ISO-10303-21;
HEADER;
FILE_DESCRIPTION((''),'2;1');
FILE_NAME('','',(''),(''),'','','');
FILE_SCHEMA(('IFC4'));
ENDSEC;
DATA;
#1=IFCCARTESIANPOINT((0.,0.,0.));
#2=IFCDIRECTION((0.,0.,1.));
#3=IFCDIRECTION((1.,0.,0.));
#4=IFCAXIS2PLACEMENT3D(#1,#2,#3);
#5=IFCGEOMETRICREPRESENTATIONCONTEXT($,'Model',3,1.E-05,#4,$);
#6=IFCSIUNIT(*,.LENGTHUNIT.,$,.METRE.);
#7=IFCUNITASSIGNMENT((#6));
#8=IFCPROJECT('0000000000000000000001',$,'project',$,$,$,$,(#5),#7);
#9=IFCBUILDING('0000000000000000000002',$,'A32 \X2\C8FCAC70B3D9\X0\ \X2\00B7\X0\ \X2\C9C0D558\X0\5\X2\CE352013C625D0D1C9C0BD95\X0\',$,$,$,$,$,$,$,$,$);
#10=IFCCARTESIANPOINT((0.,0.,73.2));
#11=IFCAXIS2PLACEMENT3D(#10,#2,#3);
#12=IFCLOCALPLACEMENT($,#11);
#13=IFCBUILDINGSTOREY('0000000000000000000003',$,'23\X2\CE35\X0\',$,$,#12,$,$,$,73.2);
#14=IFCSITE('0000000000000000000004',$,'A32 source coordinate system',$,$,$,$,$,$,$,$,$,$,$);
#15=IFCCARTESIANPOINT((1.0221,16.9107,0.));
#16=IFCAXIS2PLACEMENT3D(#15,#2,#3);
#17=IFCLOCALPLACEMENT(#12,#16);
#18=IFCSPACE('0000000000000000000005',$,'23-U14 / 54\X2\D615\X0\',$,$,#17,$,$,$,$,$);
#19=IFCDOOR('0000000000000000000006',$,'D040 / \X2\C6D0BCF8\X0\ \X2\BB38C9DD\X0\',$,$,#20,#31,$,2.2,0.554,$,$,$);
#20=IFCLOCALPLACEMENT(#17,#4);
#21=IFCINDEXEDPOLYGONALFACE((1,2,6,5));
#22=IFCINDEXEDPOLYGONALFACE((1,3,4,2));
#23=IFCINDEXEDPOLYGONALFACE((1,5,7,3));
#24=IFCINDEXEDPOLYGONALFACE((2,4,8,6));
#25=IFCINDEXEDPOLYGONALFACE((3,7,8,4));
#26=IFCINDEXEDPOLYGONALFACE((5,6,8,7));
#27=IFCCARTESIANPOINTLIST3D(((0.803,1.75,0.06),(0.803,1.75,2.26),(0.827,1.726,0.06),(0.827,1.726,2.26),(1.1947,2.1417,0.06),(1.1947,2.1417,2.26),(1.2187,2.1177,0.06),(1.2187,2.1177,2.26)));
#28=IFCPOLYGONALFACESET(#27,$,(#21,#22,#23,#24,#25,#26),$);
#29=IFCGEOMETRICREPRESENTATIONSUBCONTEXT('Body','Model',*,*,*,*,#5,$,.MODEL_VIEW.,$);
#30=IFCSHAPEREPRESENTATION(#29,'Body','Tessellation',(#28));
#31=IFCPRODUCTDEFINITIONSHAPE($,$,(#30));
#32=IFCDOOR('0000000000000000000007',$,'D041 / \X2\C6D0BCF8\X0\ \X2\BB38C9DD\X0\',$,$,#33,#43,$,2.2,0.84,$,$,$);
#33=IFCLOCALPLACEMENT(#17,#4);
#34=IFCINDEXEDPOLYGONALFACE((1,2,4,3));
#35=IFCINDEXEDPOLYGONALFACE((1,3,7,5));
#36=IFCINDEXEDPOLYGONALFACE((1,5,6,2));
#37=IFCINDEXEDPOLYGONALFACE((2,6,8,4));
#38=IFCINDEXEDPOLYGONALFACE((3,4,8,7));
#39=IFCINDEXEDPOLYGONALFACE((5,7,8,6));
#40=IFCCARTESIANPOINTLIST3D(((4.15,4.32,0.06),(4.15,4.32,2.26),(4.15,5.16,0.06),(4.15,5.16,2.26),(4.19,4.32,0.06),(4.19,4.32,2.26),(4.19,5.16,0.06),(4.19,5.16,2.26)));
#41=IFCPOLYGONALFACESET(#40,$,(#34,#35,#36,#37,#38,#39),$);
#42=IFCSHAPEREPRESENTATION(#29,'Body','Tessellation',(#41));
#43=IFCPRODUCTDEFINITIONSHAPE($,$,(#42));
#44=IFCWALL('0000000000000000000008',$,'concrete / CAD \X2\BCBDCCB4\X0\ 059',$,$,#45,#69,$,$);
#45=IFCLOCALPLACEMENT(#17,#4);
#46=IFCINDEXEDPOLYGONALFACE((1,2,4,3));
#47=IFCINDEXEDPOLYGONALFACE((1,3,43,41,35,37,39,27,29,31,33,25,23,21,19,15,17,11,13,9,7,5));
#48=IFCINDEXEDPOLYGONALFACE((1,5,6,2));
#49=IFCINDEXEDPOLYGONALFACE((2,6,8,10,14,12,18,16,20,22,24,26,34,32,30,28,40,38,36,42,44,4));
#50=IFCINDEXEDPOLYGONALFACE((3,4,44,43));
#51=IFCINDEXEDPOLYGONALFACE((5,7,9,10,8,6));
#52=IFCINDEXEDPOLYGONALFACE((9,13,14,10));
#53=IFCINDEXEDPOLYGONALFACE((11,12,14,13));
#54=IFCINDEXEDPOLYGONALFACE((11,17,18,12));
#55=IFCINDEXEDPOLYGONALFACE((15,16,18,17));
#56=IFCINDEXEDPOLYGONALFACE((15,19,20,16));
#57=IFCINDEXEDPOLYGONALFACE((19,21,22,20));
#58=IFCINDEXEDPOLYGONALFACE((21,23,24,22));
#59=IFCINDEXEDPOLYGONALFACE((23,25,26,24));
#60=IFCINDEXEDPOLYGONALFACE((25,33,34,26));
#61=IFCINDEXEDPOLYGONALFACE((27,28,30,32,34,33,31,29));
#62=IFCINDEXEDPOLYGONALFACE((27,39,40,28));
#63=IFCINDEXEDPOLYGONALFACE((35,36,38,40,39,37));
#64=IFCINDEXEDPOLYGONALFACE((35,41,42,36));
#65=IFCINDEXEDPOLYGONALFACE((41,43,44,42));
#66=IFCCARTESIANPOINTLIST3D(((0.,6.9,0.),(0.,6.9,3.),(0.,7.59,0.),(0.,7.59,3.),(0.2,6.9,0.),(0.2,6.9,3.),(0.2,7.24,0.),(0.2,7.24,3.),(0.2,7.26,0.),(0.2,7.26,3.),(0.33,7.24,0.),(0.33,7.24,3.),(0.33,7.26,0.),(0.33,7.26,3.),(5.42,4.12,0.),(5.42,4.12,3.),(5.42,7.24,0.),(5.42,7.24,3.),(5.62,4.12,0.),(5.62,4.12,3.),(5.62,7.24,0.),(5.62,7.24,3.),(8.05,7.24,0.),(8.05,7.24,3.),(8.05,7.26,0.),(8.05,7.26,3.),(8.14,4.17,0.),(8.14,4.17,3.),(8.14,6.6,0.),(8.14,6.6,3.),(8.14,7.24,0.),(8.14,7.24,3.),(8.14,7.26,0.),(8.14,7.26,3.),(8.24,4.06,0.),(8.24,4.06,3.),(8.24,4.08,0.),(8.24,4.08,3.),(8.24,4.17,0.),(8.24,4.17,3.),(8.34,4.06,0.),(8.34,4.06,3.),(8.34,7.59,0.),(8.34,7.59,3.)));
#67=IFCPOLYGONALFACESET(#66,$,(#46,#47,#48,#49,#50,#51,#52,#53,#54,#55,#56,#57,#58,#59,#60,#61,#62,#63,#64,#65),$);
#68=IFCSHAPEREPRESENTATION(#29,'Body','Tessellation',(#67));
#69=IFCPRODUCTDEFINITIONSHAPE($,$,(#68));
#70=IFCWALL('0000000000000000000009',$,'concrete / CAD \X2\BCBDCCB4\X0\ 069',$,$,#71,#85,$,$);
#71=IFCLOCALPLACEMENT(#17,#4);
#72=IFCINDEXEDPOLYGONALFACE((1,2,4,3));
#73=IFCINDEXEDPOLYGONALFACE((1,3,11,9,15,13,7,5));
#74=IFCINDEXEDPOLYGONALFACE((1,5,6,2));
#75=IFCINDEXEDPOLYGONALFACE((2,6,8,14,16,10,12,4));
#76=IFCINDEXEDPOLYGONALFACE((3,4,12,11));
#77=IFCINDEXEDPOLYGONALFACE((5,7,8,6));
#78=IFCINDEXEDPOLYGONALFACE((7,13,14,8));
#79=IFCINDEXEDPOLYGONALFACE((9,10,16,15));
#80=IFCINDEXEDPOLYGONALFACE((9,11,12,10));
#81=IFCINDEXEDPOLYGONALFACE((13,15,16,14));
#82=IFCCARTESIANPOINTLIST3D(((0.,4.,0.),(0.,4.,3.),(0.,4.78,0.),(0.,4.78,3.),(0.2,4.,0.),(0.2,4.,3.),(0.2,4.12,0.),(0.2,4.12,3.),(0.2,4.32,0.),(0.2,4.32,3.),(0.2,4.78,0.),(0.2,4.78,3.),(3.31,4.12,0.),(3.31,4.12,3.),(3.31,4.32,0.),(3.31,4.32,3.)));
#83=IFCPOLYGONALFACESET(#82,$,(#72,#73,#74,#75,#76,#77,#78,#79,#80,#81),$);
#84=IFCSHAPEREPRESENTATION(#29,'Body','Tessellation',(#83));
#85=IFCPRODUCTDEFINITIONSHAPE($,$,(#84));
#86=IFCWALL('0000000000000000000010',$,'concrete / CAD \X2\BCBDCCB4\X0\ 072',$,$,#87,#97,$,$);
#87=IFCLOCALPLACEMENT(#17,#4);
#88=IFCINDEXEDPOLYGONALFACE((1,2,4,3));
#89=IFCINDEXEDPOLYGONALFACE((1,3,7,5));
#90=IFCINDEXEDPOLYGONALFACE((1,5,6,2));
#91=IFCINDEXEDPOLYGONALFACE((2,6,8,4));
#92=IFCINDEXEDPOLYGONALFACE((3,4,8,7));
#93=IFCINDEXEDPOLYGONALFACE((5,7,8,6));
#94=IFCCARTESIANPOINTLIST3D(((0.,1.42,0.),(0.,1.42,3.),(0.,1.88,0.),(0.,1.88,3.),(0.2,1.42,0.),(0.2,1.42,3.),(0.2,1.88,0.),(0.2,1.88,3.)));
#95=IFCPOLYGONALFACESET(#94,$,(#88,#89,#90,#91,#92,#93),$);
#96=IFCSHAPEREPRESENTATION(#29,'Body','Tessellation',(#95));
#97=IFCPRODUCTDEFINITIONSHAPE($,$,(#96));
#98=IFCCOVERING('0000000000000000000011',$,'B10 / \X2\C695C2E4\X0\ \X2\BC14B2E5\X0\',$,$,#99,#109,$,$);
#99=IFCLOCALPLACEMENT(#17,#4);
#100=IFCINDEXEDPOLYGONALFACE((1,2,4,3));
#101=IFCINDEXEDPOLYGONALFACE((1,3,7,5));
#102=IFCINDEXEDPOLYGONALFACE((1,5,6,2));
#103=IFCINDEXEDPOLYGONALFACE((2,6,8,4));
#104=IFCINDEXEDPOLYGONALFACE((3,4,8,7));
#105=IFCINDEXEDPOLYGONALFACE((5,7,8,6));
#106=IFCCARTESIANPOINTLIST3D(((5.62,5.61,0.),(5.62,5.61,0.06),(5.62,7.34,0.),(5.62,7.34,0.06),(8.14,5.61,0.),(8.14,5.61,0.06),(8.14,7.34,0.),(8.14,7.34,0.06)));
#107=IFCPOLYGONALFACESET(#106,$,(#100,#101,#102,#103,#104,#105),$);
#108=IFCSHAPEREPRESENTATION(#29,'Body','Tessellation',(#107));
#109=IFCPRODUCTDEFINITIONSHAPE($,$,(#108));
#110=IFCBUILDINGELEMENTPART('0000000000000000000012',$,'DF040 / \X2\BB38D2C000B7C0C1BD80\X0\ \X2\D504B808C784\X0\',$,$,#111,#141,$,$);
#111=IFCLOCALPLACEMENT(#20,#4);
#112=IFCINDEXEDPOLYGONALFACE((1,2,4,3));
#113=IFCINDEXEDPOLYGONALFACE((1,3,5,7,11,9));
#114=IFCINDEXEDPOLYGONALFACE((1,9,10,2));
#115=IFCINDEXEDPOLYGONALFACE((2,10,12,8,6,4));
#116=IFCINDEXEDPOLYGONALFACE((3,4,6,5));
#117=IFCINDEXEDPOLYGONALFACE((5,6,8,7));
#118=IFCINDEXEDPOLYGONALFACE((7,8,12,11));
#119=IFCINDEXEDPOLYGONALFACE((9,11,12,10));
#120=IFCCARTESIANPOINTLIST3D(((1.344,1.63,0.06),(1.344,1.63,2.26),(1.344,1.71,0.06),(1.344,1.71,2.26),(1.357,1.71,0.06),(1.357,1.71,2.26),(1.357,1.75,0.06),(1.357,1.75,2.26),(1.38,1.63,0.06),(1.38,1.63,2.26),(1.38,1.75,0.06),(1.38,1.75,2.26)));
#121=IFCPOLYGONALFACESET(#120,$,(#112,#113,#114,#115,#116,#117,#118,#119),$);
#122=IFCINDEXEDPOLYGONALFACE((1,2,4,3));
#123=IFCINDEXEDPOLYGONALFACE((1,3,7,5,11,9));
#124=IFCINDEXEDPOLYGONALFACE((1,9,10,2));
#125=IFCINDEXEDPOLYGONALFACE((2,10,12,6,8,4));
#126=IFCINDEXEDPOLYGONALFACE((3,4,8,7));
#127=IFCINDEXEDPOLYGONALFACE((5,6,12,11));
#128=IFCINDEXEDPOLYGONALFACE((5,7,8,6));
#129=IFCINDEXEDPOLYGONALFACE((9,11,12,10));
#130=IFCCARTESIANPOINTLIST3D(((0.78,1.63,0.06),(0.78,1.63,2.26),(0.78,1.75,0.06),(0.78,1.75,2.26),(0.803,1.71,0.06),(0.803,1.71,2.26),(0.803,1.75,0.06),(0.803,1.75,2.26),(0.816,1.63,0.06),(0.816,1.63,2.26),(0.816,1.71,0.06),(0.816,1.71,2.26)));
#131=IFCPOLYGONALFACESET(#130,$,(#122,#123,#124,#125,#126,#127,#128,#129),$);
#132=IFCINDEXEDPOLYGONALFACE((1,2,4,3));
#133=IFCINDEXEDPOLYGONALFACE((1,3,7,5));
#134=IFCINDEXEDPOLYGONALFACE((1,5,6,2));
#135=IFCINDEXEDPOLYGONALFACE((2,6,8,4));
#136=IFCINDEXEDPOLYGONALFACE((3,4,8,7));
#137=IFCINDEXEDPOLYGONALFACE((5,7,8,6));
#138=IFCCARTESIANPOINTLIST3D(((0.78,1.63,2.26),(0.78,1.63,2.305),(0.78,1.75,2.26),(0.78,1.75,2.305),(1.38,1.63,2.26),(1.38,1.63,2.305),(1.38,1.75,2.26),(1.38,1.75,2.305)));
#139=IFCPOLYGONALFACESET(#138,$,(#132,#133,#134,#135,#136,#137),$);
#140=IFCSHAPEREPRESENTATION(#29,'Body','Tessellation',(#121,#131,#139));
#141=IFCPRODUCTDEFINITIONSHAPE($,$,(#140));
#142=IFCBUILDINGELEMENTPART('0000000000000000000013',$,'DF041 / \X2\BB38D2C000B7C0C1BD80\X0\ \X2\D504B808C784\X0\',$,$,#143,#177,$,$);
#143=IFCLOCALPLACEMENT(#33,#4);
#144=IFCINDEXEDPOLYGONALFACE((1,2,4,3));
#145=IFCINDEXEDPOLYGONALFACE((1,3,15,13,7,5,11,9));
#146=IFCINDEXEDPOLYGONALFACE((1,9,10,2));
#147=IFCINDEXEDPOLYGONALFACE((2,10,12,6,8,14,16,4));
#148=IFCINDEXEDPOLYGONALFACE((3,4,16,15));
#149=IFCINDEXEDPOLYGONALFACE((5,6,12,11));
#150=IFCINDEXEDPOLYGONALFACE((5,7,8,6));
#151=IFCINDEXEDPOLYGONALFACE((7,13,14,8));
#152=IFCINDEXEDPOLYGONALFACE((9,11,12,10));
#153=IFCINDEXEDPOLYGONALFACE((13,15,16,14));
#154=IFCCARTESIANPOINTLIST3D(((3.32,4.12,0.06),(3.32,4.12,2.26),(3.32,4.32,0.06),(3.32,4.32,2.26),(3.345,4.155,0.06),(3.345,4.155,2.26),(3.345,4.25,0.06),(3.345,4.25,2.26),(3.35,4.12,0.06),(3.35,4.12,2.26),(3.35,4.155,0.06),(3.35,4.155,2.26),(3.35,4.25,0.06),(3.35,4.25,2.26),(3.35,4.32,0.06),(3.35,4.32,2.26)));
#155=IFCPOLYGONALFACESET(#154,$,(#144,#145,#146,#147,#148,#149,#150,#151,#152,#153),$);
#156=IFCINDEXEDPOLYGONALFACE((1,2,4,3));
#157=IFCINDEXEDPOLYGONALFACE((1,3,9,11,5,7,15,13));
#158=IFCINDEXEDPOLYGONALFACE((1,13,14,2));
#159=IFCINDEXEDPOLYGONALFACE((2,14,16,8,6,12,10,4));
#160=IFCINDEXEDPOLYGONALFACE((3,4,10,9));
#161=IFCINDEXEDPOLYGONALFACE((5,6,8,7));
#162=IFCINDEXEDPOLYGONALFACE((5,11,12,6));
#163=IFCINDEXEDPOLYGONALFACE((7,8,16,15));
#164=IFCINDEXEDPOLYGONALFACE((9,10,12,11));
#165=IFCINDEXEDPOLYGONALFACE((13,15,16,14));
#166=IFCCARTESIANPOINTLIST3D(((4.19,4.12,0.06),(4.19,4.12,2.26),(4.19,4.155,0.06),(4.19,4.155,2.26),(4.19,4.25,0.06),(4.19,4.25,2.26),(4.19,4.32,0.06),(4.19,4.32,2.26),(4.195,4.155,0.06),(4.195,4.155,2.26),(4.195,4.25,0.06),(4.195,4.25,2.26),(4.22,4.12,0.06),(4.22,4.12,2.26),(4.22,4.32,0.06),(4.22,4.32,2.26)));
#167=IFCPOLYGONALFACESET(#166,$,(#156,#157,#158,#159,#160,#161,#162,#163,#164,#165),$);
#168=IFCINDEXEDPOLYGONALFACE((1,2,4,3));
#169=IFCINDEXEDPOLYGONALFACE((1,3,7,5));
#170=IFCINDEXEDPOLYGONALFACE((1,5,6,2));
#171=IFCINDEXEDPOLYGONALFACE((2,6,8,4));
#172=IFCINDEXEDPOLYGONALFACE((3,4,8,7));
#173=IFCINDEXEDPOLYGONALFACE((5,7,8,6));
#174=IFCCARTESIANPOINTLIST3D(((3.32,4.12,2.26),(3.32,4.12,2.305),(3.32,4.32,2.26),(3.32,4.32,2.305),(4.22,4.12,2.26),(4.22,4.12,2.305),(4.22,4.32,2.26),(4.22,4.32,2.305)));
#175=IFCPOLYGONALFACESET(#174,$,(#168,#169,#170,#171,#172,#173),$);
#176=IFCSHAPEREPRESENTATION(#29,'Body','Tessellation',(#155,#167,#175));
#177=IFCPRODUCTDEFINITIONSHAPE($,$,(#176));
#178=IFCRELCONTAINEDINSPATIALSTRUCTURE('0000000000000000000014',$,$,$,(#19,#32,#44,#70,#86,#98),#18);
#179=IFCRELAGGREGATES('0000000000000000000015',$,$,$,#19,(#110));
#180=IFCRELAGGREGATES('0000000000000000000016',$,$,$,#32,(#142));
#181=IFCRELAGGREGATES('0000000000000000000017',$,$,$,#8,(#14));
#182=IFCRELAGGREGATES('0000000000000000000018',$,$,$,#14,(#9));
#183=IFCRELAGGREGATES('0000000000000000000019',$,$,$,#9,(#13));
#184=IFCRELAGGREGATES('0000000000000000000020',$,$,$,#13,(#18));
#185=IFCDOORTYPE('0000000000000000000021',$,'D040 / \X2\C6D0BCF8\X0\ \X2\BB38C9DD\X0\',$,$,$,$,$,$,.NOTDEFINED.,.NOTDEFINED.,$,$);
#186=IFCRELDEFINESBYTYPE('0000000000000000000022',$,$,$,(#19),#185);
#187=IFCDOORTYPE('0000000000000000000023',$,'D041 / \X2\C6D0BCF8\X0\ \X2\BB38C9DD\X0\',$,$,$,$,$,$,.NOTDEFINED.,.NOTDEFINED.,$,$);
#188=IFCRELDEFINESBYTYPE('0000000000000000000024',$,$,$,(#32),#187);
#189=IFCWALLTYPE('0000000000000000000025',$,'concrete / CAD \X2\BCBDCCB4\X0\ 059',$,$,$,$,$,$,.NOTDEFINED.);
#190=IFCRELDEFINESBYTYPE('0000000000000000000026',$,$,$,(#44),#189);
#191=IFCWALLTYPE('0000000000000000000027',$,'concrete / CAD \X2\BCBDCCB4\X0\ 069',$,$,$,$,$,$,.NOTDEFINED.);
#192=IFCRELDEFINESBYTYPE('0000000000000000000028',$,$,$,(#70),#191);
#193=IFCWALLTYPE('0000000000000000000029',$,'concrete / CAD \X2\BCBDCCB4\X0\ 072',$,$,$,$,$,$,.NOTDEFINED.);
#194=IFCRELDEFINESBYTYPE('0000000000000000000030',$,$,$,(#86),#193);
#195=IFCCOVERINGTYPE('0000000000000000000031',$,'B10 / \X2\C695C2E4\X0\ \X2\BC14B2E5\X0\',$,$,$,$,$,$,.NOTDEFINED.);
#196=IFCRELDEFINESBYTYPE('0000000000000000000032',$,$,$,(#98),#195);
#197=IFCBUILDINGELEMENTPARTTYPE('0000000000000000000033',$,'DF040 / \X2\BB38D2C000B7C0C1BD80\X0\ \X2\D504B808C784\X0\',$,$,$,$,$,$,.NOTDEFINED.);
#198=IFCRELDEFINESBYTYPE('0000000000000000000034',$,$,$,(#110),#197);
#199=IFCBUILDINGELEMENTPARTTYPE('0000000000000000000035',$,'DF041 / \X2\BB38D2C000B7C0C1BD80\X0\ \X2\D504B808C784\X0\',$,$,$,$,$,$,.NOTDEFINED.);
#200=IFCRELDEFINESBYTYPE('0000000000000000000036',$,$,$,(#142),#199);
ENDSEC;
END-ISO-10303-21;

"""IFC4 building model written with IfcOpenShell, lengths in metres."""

from ifc_helpers import new_model, si_unit, frame, origin, origin_with_axes, place, context, subcontext, project, spatial, polyline, outline, extrude, source, transform, mapped, type_object, type_shapes, element, aggregate, save


model = new_model("IFC4")

# Units and contexts
model_context = context("Model", 3, precision=1e-05, world=origin_with_axes())
body_context = subcontext(model_context, "Body", "Model", "MODEL_VIEW")
ifc_project = project(units=[si_unit("LENGTHUNIT", "METRE")], contexts=[model_context])

# Site, building, storey, space
storey_placement = place(None, frame((0.0, 0.0, 73.2), z_axis=(0.0, 0.0, 1.0), x_axis=(1.0, 0.0, 0.0)))
space_placement = place(storey_placement, frame((1.0221, 16.9107, 0.0), z_axis=(0.0, 0.0, 1.0), x_axis=(1.0, 0.0, 0.0)))
site = spatial("IfcSite", under=ifc_project, Name="A32 source coordinate system")
building = spatial("IfcBuilding", under=site, Name="A32 주거동 · 지하5층–옥탑지붕")
storey = spatial("IfcBuildingStorey", under=building, at=storey_placement, Name="23층", Elevation=73.2)
space = spatial("IfcSpace", under=storey, at=space_placement, Name="23-U14 / 54형")

# Doors
door_type_1 = type_object("IfcDoorType", Name="D040 / 원본 문짝", OperationType="NOTDEFINED", PredefinedType="NOTDEFINED")
shared_shape_1 = source(origin(), body_context, "Body", "SweptSolid", [
    extrude(outline(polyline([(0.803, 1.75), (1.1947, 2.1417), (1.2187, 2.1177), (0.827, 1.726), (0.803, 1.75)])), frame((0.0, 0.0, 0.06)), (0.0, 0.0, 1.0), 2.2),
])
type_shapes(door_type_1, [shared_shape_1])
door_1_placement = place(space_placement, origin_with_axes())
door_1 = element("IfcDoor", 1, at=door_1_placement, inside=space, type_object=door_type_1, Name="D040 / 원본 문짝", OverallHeight=2.2, OverallWidth=0.554, context=body_context, shape_type="MappedRepresentation", body=[
    mapped(shared_shape_1, transform((0.0, 0.0, 0.0), scale=1.0)),
])
door_type_2 = type_object("IfcDoorType", Name="D041 / 원본 문짝", OperationType="NOTDEFINED", PredefinedType="NOTDEFINED")
shared_shape_2 = source(origin(), body_context, "Body", "SweptSolid", [
    extrude(outline(polyline([(4.15, 5.16), (4.19, 5.16), (4.19, 4.32), (4.15, 4.32), (4.15, 5.16)])), frame((0.0, 0.0, 0.06)), (0.0, 0.0, 1.0), 2.2),
])
type_shapes(door_type_2, [shared_shape_2])
door_2_placement = place(space_placement, origin_with_axes())
door_2 = element("IfcDoor", 2, at=door_2_placement, inside=space, type_object=door_type_2, Name="D041 / 원본 문짝", OverallHeight=2.2, OverallWidth=0.84, context=body_context, shape_type="MappedRepresentation", body=[
    mapped(shared_shape_2, transform((0.0, 0.0, 0.0), scale=1.0)),
])

# Walls
wall_type_1 = type_object("IfcWallType", Name="concrete / CAD 벽체 059", PredefinedType="NOTDEFINED")
shared_shape_3 = source(origin(), body_context, "Body", "SweptSolid", [
    extrude(outline(polyline([(8.05, 7.26), (8.05, 7.24), (5.62, 7.24), (5.62, 4.12), (5.42, 4.12), (5.42, 7.24), (0.33, 7.24), (0.33, 7.26), (0.2, 7.26), (0.2, 7.24), (0.2, 6.9), (0.0, 6.9), (0.0, 7.59), (8.34, 7.59), (8.34, 4.06), (8.24, 4.06), (8.24, 4.08), (8.24, 4.17), (8.14, 4.17), (8.14, 6.6), (8.14, 7.24), (8.14, 7.26), (8.05, 7.26)])), origin(), (0.0, 0.0, 1.0), 3.0),
])
type_shapes(wall_type_1, [shared_shape_3])
wall_1_placement = place(space_placement, origin_with_axes())
element("IfcWall", 3, at=wall_1_placement, inside=space, type_object=wall_type_1, Name="concrete / CAD 벽체 059", context=body_context, shape_type="MappedRepresentation", body=[
    mapped(shared_shape_3, transform((0.0, 0.0, 0.0), scale=1.0)),
])
wall_type_2 = type_object("IfcWallType", Name="concrete / CAD 벽체 069", PredefinedType="NOTDEFINED")
shared_shape_4 = source(origin(), body_context, "Body", "SweptSolid", [
    extrude(outline(polyline([(0.2, 4.12), (0.2, 4.0), (0.0, 4.0), (0.0, 4.78), (0.2, 4.78), (0.2, 4.32), (3.31, 4.32), (3.31, 4.12), (0.2, 4.12)])), origin(), (0.0, 0.0, 1.0), 3.0),
])
type_shapes(wall_type_2, [shared_shape_4])
wall_2_placement = place(space_placement, origin_with_axes())
element("IfcWall", 4, at=wall_2_placement, inside=space, type_object=wall_type_2, Name="concrete / CAD 벽체 069", context=body_context, shape_type="MappedRepresentation", body=[
    mapped(shared_shape_4, transform((0.0, 0.0, 0.0), scale=1.0)),
])
wall_type_3 = type_object("IfcWallType", Name="concrete / CAD 벽체 072", PredefinedType="NOTDEFINED")
shared_shape_5 = source(origin(), body_context, "Body", "SweptSolid", [
    extrude(outline(polyline([(0.2, 1.88), (0.2, 1.42), (0.0, 1.42), (0.0, 1.88), (0.2, 1.88)])), origin(), (0.0, 0.0, 1.0), 3.0),
])
type_shapes(wall_type_3, [shared_shape_5])
wall_3_placement = place(space_placement, origin_with_axes())
element("IfcWall", 5, at=wall_3_placement, inside=space, type_object=wall_type_3, Name="concrete / CAD 벽체 072", context=body_context, shape_type="MappedRepresentation", body=[
    mapped(shared_shape_5, transform((0.0, 0.0, 0.0), scale=1.0)),
])

# Covering
covering_type_1 = type_object("IfcCoveringType", Name="B10 / 욕실 바닥", PredefinedType="NOTDEFINED")
shared_shape_6 = source(origin(), body_context, "Body", "SweptSolid", [
    extrude(outline(polyline([(8.14, 5.61), (5.62, 5.61), (5.62, 7.34), (8.14, 7.34), (8.14, 5.61)])), origin(), (0.0, 0.0, 1.0), 0.06),
])
type_shapes(covering_type_1, [shared_shape_6])
covering_1_placement = place(space_placement, origin_with_axes())
element("IfcCovering", 6, at=covering_1_placement, inside=space, type_object=covering_type_1, Name="B10 / 욕실 바닥", context=body_context, shape_type="MappedRepresentation", body=[
    mapped(shared_shape_6, transform((0.0, 0.0, 0.0), scale=1.0)),
])

# Building element parts
building_element_part_type_1 = type_object("IfcBuildingElementPartType", Name="DF040 / 문틀·상부 프레임", PredefinedType="NOTDEFINED")
shared_shape_7 = source(origin(), body_context, "Body", "SweptSolid", [
    extrude(outline(polyline([(1.344, 1.63), (1.344, 1.71), (1.357, 1.71), (1.357, 1.75), (1.38, 1.75), (1.38, 1.63), (1.344, 1.63)])), frame((0.0, 0.0, 0.06)), (0.0, 0.0, 1.0), 2.2),
    extrude(outline(polyline([(0.78, 1.75), (0.803, 1.75), (0.803, 1.71), (0.816, 1.71), (0.816, 1.63), (0.78, 1.63), (0.78, 1.75)])), frame((0.0, 0.0, 0.06)), (0.0, 0.0, 1.0), 2.2),
    extrude(outline(polyline([(0.78, 1.63), (0.78, 1.75), (1.38, 1.75), (1.38, 1.63), (0.78, 1.63)])), frame((0.0, 0.0, 2.26)), (0.0, 0.0, 1.0), 0.045),
])
type_shapes(building_element_part_type_1, [shared_shape_7])
building_element_part_1_placement = place(door_1_placement, origin_with_axes())
building_element_part_1 = element("IfcBuildingElementPart", 7, at=building_element_part_1_placement, type_object=building_element_part_type_1, Name="DF040 / 문틀·상부 프레임", context=body_context, shape_type="MappedRepresentation", body=[
    mapped(shared_shape_7, transform((0.0, 0.0, 0.0), scale=1.0)),
])
aggregate(door_1, [building_element_part_1])
building_element_part_type_2 = type_object("IfcBuildingElementPartType", Name="DF041 / 문틀·상부 프레임", PredefinedType="NOTDEFINED")
shared_shape_8 = source(origin(), body_context, "Body", "SweptSolid", [
    extrude(outline(polyline([(3.35, 4.32), (3.35, 4.25), (3.345, 4.25), (3.345, 4.155), (3.35, 4.155), (3.35, 4.12), (3.32, 4.12), (3.32, 4.32), (3.35, 4.32)])), frame((0.0, 0.0, 0.06)), (0.0, 0.0, 1.0), 2.2),
    extrude(outline(polyline([(4.22, 4.12), (4.19, 4.12), (4.19, 4.155), (4.195, 4.155), (4.195, 4.25), (4.19, 4.25), (4.19, 4.32), (4.22, 4.32), (4.22, 4.12)])), frame((0.0, 0.0, 0.06)), (0.0, 0.0, 1.0), 2.2),
    extrude(outline(polyline([(3.32, 4.12), (3.32, 4.32), (4.22, 4.32), (4.22, 4.12), (3.32, 4.12)])), frame((0.0, 0.0, 2.26)), (0.0, 0.0, 1.0), 0.045),
])
type_shapes(building_element_part_type_2, [shared_shape_8])
building_element_part_2_placement = place(door_2_placement, origin_with_axes())
building_element_part_2 = element("IfcBuildingElementPart", 8, at=building_element_part_2_placement, type_object=building_element_part_type_2, Name="DF041 / 문틀·상부 프레임", context=body_context, shape_type="MappedRepresentation", body=[
    mapped(shared_shape_8, transform((0.0, 0.0, 0.0), scale=1.0)),
])
aggregate(door_2, [building_element_part_2])

save(model, "model.ifc")
